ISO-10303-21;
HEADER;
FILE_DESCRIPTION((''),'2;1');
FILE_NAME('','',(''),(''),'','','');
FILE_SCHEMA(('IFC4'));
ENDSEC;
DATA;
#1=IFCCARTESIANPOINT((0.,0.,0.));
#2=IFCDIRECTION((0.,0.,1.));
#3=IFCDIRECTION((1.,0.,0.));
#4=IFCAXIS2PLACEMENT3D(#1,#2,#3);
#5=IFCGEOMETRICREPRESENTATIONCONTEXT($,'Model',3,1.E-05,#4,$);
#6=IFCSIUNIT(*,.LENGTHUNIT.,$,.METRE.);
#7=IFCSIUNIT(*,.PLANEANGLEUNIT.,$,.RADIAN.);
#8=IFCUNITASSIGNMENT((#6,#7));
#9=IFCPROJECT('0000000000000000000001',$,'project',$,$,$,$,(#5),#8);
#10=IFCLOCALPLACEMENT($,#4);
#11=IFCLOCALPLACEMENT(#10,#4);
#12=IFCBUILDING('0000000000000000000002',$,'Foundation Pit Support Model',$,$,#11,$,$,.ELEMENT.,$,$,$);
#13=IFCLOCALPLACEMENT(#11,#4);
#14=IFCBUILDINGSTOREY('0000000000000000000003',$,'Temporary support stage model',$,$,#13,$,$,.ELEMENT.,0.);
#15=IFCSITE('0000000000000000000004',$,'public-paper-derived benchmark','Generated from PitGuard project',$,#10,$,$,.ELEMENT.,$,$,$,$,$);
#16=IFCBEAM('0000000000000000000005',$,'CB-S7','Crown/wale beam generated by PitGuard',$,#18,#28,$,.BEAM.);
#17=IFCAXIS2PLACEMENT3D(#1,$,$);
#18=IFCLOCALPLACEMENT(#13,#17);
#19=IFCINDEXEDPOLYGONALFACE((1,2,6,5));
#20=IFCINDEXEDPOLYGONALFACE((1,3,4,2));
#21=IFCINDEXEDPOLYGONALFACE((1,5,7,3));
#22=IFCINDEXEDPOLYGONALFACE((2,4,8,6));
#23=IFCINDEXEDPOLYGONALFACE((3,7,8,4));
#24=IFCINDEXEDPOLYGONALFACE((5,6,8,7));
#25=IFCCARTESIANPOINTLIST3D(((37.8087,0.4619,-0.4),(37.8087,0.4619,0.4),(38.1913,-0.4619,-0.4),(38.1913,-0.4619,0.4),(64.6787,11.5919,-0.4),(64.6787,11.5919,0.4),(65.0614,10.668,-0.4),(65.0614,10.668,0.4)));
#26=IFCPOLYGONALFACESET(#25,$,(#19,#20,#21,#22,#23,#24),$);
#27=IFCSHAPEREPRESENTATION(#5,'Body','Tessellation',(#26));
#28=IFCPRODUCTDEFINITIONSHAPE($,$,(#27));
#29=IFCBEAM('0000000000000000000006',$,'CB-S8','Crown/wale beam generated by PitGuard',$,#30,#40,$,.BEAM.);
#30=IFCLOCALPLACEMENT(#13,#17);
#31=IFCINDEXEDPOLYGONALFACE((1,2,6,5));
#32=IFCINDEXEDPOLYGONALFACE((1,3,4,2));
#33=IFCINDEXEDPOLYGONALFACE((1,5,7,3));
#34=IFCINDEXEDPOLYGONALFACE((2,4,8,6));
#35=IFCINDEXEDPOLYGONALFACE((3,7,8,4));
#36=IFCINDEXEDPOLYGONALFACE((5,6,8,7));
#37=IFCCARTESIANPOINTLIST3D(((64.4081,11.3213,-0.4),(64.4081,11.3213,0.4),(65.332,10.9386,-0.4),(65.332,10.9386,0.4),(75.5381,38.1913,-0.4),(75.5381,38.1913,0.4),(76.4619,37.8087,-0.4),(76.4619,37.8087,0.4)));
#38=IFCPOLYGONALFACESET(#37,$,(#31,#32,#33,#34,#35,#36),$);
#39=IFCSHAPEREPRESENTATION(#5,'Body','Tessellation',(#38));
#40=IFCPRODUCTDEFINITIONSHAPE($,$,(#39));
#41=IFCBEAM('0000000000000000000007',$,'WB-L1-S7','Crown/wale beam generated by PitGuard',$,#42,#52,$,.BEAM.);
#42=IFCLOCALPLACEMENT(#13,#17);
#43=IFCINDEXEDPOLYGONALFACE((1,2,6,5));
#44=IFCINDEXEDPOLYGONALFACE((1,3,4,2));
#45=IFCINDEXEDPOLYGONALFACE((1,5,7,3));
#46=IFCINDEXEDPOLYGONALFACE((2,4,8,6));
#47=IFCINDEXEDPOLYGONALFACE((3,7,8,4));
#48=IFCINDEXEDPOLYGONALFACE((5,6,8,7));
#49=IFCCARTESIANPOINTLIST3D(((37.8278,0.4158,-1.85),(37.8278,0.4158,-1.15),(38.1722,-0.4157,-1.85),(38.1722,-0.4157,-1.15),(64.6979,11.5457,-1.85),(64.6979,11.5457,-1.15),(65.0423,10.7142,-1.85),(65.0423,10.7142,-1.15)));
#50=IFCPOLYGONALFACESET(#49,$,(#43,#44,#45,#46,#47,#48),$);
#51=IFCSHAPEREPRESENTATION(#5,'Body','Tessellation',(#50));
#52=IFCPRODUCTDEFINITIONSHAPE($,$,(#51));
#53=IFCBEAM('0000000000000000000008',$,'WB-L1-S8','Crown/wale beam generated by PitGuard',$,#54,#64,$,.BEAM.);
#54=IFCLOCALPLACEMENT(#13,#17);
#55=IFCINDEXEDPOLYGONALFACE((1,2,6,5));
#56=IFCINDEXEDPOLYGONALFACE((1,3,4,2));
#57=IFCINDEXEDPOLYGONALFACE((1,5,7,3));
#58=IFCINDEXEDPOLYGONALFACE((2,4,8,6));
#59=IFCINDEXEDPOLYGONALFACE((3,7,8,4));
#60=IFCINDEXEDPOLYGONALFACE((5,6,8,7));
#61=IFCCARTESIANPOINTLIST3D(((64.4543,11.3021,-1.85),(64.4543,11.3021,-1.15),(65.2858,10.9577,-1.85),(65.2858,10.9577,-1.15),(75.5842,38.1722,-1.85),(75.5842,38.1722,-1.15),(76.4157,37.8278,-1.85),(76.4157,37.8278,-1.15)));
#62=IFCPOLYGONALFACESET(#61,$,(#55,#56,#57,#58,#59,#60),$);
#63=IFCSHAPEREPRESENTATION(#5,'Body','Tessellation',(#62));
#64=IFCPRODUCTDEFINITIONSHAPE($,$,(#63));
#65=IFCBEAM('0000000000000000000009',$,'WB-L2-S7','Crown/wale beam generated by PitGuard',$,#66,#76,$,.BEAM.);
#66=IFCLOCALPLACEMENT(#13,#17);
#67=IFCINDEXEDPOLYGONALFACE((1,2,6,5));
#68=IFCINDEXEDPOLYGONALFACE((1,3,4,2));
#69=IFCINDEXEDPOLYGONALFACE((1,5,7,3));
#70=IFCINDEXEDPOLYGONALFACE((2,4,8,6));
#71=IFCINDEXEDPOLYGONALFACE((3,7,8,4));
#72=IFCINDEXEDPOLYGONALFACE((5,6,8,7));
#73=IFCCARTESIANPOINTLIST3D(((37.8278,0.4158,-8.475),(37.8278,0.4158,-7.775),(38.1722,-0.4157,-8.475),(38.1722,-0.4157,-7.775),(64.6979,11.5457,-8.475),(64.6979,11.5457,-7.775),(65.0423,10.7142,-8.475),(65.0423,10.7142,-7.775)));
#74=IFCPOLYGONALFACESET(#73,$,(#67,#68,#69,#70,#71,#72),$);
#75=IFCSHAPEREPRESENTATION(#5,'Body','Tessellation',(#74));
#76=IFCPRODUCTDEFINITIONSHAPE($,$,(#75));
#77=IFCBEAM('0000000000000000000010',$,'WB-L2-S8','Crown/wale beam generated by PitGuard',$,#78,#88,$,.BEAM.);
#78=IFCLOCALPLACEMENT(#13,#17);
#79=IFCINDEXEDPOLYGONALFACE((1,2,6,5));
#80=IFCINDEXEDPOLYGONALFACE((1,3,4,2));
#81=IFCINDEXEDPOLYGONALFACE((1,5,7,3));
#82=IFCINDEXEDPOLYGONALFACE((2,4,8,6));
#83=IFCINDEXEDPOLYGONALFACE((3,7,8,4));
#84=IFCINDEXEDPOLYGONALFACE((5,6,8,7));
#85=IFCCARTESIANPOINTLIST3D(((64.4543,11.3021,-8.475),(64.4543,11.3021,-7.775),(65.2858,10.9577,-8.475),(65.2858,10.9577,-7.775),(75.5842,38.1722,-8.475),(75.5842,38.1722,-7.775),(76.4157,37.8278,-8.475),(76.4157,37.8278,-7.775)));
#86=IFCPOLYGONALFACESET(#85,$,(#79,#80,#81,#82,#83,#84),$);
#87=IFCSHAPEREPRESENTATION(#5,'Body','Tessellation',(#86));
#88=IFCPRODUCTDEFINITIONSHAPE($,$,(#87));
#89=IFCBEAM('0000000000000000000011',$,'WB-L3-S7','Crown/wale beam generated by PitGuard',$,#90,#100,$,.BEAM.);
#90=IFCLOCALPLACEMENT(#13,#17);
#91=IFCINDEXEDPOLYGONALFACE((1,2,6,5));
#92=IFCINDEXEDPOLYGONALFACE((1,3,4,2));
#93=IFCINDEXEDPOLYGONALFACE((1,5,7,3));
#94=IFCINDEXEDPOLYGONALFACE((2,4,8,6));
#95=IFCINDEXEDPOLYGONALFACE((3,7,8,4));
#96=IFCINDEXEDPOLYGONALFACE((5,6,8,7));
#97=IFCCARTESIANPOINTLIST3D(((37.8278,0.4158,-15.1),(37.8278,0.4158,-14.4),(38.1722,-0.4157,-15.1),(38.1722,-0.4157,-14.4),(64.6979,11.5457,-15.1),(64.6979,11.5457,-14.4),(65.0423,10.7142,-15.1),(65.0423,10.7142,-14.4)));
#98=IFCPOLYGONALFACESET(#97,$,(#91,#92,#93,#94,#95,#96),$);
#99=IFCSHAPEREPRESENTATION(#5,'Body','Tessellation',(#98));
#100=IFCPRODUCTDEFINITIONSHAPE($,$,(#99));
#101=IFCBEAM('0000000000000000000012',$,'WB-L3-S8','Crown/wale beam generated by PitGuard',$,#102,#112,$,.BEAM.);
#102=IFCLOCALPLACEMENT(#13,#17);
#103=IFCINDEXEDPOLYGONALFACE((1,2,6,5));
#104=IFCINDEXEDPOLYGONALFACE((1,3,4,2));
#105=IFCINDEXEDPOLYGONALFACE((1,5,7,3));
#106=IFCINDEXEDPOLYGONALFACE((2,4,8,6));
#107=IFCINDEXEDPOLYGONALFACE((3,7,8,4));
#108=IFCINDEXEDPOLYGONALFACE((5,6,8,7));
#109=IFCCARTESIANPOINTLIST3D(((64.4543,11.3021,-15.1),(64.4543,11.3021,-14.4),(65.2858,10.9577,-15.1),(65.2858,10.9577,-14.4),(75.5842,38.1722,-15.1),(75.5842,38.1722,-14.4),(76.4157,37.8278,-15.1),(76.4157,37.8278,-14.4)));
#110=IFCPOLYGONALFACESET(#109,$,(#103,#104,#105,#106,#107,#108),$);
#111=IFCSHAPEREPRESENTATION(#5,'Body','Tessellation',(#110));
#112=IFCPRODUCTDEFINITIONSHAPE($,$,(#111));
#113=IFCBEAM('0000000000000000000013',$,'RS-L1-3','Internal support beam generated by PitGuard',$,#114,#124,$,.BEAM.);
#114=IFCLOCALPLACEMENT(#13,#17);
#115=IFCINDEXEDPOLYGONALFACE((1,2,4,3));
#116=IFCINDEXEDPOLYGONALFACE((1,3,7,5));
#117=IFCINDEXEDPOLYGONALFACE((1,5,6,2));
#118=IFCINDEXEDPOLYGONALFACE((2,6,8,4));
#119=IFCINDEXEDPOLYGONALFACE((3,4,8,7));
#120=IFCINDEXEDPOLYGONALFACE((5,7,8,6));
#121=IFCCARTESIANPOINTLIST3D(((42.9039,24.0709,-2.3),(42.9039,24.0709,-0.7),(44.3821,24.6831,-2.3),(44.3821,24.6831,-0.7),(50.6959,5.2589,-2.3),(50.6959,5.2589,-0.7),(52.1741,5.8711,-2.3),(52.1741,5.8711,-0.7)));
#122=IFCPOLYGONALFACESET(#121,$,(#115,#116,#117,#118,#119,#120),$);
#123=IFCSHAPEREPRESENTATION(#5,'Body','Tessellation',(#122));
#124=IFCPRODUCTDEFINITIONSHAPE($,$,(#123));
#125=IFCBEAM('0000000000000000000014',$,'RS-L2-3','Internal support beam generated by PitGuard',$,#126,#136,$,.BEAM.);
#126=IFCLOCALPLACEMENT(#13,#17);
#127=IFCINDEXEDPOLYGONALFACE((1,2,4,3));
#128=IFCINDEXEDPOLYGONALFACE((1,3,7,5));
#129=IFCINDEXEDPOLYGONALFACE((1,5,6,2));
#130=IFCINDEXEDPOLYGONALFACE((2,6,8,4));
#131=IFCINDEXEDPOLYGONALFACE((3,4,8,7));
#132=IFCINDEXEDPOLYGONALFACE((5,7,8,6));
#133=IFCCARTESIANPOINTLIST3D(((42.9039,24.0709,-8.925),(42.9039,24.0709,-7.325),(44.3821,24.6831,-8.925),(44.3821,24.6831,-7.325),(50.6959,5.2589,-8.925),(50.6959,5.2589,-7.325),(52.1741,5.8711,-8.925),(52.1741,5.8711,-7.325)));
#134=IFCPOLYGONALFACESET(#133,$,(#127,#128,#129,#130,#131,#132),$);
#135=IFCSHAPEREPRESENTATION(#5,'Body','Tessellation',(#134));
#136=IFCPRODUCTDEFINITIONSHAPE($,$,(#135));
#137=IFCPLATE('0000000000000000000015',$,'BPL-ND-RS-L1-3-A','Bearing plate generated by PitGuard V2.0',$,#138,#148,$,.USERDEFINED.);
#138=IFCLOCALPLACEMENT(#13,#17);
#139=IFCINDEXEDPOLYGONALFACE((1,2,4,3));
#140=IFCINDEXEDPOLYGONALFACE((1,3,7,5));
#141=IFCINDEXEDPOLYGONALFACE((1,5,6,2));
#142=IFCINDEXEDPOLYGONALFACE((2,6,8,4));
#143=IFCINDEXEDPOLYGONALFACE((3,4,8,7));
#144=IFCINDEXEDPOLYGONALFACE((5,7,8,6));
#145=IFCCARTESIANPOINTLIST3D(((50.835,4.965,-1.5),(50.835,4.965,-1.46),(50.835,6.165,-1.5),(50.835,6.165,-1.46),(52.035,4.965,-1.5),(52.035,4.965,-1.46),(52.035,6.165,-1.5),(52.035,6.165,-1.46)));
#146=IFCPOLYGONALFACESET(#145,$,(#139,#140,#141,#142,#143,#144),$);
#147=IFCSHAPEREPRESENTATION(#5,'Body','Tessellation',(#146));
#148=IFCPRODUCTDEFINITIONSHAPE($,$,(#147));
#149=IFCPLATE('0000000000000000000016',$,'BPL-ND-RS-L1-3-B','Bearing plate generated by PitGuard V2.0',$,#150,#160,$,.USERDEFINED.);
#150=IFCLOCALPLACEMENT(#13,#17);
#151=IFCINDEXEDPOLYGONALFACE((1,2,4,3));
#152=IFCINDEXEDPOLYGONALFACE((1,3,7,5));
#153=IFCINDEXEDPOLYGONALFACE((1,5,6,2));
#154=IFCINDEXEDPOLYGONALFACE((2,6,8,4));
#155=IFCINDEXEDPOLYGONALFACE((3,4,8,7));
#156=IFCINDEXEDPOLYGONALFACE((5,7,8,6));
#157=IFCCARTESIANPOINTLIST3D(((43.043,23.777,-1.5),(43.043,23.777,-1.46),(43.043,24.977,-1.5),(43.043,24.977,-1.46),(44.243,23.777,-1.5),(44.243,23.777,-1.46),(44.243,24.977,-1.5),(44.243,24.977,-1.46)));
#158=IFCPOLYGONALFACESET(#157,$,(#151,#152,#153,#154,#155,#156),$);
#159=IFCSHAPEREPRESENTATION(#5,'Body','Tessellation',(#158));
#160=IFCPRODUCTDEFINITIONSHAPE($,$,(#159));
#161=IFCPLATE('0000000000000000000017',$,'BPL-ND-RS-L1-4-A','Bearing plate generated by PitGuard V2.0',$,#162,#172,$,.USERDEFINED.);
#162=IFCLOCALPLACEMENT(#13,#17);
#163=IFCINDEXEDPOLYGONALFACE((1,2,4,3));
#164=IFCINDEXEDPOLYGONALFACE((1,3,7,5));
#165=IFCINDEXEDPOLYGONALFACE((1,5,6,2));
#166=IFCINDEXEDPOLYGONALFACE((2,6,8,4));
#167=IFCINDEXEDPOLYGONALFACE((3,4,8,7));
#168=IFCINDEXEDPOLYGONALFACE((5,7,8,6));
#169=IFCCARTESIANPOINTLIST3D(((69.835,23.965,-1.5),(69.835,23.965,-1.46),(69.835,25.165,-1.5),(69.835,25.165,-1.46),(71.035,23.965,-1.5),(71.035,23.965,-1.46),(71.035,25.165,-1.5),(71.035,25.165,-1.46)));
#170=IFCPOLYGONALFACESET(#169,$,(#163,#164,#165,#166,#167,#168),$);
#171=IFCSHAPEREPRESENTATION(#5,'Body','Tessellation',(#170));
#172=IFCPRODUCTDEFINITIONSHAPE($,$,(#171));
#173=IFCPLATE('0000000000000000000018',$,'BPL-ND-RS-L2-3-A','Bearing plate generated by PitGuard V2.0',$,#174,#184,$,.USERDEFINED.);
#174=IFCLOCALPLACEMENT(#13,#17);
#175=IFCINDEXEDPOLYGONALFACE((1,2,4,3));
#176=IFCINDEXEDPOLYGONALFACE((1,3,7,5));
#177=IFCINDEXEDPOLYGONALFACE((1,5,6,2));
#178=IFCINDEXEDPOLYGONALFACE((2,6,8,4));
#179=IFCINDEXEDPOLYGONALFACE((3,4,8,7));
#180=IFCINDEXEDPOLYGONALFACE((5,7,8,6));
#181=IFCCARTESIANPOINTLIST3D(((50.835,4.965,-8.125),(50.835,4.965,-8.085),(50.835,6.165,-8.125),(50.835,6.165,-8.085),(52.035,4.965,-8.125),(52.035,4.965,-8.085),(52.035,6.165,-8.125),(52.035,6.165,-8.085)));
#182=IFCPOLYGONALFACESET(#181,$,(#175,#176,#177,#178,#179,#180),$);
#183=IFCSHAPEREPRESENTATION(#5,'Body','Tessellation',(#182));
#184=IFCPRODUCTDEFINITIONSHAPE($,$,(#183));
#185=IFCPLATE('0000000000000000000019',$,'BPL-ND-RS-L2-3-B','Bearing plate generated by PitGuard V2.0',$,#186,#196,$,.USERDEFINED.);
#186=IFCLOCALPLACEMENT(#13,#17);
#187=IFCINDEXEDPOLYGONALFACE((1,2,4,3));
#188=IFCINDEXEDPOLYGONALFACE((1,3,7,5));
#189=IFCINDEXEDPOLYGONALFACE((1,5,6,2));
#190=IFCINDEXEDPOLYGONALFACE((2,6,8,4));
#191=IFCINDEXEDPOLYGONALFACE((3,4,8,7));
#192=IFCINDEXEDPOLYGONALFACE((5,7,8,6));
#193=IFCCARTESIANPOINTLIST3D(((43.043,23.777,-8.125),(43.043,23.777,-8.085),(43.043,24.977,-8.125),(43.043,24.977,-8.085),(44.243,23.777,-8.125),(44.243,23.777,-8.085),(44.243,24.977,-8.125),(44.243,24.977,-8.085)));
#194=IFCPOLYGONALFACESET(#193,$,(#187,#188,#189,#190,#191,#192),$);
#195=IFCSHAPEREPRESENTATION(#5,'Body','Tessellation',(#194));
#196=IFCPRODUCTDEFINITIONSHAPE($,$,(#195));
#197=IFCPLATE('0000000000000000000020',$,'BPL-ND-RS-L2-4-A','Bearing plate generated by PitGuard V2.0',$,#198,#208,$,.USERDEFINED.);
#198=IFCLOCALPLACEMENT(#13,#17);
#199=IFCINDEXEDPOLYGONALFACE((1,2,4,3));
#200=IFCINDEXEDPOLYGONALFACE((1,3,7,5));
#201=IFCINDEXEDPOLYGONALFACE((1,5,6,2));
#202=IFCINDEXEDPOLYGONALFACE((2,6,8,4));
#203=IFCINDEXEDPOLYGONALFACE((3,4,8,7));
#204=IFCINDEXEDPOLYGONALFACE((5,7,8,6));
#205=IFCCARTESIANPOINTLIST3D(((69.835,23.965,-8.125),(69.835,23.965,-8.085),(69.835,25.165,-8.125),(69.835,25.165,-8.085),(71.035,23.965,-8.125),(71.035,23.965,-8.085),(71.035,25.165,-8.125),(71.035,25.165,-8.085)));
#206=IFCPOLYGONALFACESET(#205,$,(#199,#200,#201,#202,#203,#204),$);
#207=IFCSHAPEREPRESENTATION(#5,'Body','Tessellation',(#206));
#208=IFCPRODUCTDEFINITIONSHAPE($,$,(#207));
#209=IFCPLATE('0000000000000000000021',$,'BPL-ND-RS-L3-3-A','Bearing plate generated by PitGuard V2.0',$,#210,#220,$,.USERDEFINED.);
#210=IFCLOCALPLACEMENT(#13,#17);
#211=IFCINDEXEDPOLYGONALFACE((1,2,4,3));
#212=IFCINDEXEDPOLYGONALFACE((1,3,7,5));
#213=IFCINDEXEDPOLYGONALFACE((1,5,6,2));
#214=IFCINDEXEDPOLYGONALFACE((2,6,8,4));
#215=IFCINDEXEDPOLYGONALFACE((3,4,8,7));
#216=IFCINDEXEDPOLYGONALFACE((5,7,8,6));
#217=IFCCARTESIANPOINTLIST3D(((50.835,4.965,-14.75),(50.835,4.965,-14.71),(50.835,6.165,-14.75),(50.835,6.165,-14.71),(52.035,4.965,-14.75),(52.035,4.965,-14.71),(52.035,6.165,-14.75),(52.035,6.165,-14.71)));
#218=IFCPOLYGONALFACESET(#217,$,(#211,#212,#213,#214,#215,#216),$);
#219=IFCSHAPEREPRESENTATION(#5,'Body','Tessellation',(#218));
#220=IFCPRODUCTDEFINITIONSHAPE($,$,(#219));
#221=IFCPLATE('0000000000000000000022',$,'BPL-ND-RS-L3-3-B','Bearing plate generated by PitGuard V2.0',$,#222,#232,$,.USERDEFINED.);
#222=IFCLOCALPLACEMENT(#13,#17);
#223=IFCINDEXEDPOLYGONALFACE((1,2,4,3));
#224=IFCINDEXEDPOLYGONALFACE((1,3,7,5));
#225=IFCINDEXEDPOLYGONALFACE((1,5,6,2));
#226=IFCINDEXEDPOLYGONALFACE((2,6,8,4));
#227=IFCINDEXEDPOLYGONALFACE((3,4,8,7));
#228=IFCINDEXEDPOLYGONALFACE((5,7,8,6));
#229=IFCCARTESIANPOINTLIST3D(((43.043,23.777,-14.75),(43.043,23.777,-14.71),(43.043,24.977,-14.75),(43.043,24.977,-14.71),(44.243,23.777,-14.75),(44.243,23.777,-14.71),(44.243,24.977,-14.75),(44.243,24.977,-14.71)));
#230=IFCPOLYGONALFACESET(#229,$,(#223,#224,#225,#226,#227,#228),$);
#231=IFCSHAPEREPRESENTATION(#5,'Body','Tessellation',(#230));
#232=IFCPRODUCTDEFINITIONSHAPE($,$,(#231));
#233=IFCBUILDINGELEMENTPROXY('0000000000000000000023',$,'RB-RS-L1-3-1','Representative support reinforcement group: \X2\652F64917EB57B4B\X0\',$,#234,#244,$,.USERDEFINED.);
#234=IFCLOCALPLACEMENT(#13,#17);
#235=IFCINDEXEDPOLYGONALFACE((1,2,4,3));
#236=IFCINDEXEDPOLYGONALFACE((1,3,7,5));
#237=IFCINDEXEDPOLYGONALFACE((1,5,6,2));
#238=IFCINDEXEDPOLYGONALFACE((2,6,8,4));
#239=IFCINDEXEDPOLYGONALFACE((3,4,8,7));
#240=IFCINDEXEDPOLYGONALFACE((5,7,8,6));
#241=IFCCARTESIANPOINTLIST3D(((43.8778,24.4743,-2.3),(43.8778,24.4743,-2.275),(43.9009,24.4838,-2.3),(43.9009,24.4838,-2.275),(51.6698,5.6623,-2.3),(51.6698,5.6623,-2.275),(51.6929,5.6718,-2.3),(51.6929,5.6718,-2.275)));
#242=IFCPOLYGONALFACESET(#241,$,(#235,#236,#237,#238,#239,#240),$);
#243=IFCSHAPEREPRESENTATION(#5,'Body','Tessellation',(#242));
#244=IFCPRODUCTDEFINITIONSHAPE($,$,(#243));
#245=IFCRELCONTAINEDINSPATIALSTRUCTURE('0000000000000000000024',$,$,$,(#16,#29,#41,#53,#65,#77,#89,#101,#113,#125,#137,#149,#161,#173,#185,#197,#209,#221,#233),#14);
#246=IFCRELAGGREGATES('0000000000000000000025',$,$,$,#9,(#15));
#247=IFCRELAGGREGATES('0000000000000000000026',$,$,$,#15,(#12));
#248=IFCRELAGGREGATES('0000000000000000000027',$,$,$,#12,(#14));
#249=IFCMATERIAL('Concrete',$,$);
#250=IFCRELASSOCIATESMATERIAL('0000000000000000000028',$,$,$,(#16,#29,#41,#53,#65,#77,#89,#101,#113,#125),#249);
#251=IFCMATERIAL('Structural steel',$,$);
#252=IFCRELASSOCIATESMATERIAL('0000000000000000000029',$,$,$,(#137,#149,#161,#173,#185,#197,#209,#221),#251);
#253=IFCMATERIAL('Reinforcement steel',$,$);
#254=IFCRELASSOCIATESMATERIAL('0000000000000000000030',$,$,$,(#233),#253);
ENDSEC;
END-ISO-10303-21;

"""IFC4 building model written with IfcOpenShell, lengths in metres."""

from ifc_helpers import new_model, si_unit, frame, origin_with_axes, origin_2d, place, context, project, spatial, rectangle, extrude, material, element, save


model = new_model("IFC4")

# Units and contexts
model_context = context("Model", 3, precision=1e-05, world=origin_with_axes())
ifc_project = project(units=[si_unit("LENGTHUNIT", "METRE"), si_unit("PLANEANGLEUNIT", "RADIAN")], contexts=[model_context])

# Site, building, storey
site_placement = place(None, origin_with_axes())
site = spatial("IfcSite", under=ifc_project, at=site_placement, Name="public-paper-derived benchmark", Description="Generated from PitGuard project", CompositionType="ELEMENT")
building_placement = place(site_placement, origin_with_axes())
building = spatial("IfcBuilding", under=site, at=building_placement, Name="Foundation Pit Support Model", CompositionType="ELEMENT")
storey_placement = place(building_placement, origin_with_axes())
storey = spatial("IfcBuildingStorey", under=building, at=storey_placement, Name="Temporary support stage model", CompositionType="ELEMENT", Elevation=0.0)

# Beams
ifc_material_1 = material(Name="Concrete")
for number, where, z_axis, x_axis, name in (
    (1, (51.435, 5.565, -0.4), (0.0, 0.0, 1.0), (0.92388, 0.382683, 0.0), "CB-S7"),
    (2, (70.435, 24.565, -0.4), (0.0, 0.0, 1.0), (0.382683, 0.92388, 0.0), "CB-S8"),
):
    element("IfcBeam", number, at=place(storey_placement, frame(where, z_axis=z_axis, x_axis=x_axis)), inside=storey, material=ifc_material_1, Name=name, Description="Crown/wale beam generated by PitGuard", PredefinedType="BEAM", context=model_context, shape_type="SweptSolid", body=[
        extrude(rectangle(XDim=29.0839, YDim=1.0, at=origin_2d()), origin_with_axes(), (0.0, 0.0, 1.0), 0.8),
    ])
for number, where, z_axis, x_axis, name in (
    (3, (51.435, 5.565, -1.85), (0.0, 0.0, 1.0), (0.92388, 0.382683, 0.0), "WB-L1-S7"),
    (4, (70.435, 24.565, -1.85), (0.0, 0.0, 1.0), (0.382683, 0.92388, 0.0), "WB-L1-S8"),
    (5, (51.435, 5.565, -8.475), (0.0, 0.0, 1.0), (0.92388, 0.382683, 0.0), "WB-L2-S7"),
    (6, (70.435, 24.565, -8.475), (0.0, 0.0, 1.0), (0.382683, 0.92388, 0.0), "WB-L2-S8"),
    (7, (51.435, 5.565, -15.1), (0.0, 0.0, 1.0), (0.92388, 0.382683, 0.0), "WB-L3-S7"),
    (8, (70.435, 24.565, -15.1), (0.0, 0.0, 1.0), (0.382683, 0.92388, 0.0), "WB-L3-S8"),
):
    element("IfcBeam", number, at=place(storey_placement, frame(where, z_axis=z_axis, x_axis=x_axis)), inside=storey, material=ifc_material_1, Name=name, Description="Crown/wale beam generated by PitGuard", PredefinedType="BEAM", context=model_context, shape_type="SweptSolid", body=[
        extrude(rectangle(XDim=29.0839, YDim=0.9, at=origin_2d()), origin_with_axes(), (0.0, 0.0, 1.0), 0.7),
    ])
for number, where, z_axis, x_axis, name in (
    (9, (47.539, 14.971, -2.3), (0.0, 0.0, 1.0), (-0.382676, 0.923883, 0.0), "RS-L1-3"),
    (10, (47.539, 14.971, -8.925), (0.0, 0.0, 1.0), (-0.382676, 0.923883, 0.0), "RS-L2-3"),
):
    element("IfcBeam", number, at=place(storey_placement, frame(where, z_axis=z_axis, x_axis=x_axis)), inside=storey, material=ifc_material_1, Name=name, Description="Internal support beam generated by PitGuard", PredefinedType="BEAM", context=model_context, shape_type="SweptSolid", body=[
        extrude(rectangle(XDim=20.3619, YDim=1.6, at=origin_2d()), origin_with_axes(), (0.0, 0.0, 1.0), 1.6),
    ])

# Plates
ifc_material_2 = material(Name="Structural steel")
for number, where, z_axis, x_axis, name in (
    (11, (51.435, 5.565, -1.5), (0.0, 0.0, 1.0), (1.0, 0.0, 0.0), "BPL-ND-RS-L1-3-A"),
    (12, (43.643, 24.377, -1.5), (0.0, 0.0, 1.0), (1.0, 0.0, 0.0), "BPL-ND-RS-L1-3-B"),
    (13, (70.435, 24.565, -1.5), (0.0, 0.0, 1.0), (1.0, 0.0, 0.0), "BPL-ND-RS-L1-4-A"),
    (14, (51.435, 5.565, -8.125), (0.0, 0.0, 1.0), (1.0, 0.0, 0.0), "BPL-ND-RS-L2-3-A"),
    (15, (43.643, 24.377, -8.125), (0.0, 0.0, 1.0), (1.0, 0.0, 0.0), "BPL-ND-RS-L2-3-B"),
    (16, (70.435, 24.565, -8.125), (0.0, 0.0, 1.0), (1.0, 0.0, 0.0), "BPL-ND-RS-L2-4-A"),
    (17, (51.435, 5.565, -14.75), (0.0, 0.0, 1.0), (1.0, 0.0, 0.0), "BPL-ND-RS-L3-3-A"),
    (18, (43.643, 24.377, -14.75), (0.0, 0.0, 1.0), (1.0, 0.0, 0.0), "BPL-ND-RS-L3-3-B"),
):
    element("IfcPlate", number, at=place(storey_placement, frame(where, z_axis=z_axis, x_axis=x_axis)), inside=storey, material=ifc_material_2, Name=name, Description="Bearing plate generated by PitGuard V2.0", PredefinedType="USERDEFINED", context=model_context, shape_type="SweptSolid", body=[
        extrude(rectangle(XDim=1.2, YDim=1.2, at=origin_2d()), origin_with_axes(), (0.0, 0.0, 1.0), 0.04),
    ])

# Building element proxy
ifc_material_3 = material(Name="Reinforcement steel")
proxy_1_placement = place(storey_placement, frame((47.7854, 15.073, -2.3), z_axis=(0.0, 0.0, 1.0), x_axis=(-0.382676, 0.923883, 0.0)))
element("IfcBuildingElementProxy", 19, at=proxy_1_placement, inside=storey, material=ifc_material_3, Name="RB-RS-L1-3-1", Description="Representative support reinforcement group: 支撑纵筋", PredefinedType="USERDEFINED", context=model_context, shape_type="SweptSolid", body=[
    extrude(rectangle(XDim=20.3619, YDim=0.025, at=origin_2d()), origin_with_axes(), (0.0, 0.0, 1.0), 0.025),
])

save(model, "model.ifc")
